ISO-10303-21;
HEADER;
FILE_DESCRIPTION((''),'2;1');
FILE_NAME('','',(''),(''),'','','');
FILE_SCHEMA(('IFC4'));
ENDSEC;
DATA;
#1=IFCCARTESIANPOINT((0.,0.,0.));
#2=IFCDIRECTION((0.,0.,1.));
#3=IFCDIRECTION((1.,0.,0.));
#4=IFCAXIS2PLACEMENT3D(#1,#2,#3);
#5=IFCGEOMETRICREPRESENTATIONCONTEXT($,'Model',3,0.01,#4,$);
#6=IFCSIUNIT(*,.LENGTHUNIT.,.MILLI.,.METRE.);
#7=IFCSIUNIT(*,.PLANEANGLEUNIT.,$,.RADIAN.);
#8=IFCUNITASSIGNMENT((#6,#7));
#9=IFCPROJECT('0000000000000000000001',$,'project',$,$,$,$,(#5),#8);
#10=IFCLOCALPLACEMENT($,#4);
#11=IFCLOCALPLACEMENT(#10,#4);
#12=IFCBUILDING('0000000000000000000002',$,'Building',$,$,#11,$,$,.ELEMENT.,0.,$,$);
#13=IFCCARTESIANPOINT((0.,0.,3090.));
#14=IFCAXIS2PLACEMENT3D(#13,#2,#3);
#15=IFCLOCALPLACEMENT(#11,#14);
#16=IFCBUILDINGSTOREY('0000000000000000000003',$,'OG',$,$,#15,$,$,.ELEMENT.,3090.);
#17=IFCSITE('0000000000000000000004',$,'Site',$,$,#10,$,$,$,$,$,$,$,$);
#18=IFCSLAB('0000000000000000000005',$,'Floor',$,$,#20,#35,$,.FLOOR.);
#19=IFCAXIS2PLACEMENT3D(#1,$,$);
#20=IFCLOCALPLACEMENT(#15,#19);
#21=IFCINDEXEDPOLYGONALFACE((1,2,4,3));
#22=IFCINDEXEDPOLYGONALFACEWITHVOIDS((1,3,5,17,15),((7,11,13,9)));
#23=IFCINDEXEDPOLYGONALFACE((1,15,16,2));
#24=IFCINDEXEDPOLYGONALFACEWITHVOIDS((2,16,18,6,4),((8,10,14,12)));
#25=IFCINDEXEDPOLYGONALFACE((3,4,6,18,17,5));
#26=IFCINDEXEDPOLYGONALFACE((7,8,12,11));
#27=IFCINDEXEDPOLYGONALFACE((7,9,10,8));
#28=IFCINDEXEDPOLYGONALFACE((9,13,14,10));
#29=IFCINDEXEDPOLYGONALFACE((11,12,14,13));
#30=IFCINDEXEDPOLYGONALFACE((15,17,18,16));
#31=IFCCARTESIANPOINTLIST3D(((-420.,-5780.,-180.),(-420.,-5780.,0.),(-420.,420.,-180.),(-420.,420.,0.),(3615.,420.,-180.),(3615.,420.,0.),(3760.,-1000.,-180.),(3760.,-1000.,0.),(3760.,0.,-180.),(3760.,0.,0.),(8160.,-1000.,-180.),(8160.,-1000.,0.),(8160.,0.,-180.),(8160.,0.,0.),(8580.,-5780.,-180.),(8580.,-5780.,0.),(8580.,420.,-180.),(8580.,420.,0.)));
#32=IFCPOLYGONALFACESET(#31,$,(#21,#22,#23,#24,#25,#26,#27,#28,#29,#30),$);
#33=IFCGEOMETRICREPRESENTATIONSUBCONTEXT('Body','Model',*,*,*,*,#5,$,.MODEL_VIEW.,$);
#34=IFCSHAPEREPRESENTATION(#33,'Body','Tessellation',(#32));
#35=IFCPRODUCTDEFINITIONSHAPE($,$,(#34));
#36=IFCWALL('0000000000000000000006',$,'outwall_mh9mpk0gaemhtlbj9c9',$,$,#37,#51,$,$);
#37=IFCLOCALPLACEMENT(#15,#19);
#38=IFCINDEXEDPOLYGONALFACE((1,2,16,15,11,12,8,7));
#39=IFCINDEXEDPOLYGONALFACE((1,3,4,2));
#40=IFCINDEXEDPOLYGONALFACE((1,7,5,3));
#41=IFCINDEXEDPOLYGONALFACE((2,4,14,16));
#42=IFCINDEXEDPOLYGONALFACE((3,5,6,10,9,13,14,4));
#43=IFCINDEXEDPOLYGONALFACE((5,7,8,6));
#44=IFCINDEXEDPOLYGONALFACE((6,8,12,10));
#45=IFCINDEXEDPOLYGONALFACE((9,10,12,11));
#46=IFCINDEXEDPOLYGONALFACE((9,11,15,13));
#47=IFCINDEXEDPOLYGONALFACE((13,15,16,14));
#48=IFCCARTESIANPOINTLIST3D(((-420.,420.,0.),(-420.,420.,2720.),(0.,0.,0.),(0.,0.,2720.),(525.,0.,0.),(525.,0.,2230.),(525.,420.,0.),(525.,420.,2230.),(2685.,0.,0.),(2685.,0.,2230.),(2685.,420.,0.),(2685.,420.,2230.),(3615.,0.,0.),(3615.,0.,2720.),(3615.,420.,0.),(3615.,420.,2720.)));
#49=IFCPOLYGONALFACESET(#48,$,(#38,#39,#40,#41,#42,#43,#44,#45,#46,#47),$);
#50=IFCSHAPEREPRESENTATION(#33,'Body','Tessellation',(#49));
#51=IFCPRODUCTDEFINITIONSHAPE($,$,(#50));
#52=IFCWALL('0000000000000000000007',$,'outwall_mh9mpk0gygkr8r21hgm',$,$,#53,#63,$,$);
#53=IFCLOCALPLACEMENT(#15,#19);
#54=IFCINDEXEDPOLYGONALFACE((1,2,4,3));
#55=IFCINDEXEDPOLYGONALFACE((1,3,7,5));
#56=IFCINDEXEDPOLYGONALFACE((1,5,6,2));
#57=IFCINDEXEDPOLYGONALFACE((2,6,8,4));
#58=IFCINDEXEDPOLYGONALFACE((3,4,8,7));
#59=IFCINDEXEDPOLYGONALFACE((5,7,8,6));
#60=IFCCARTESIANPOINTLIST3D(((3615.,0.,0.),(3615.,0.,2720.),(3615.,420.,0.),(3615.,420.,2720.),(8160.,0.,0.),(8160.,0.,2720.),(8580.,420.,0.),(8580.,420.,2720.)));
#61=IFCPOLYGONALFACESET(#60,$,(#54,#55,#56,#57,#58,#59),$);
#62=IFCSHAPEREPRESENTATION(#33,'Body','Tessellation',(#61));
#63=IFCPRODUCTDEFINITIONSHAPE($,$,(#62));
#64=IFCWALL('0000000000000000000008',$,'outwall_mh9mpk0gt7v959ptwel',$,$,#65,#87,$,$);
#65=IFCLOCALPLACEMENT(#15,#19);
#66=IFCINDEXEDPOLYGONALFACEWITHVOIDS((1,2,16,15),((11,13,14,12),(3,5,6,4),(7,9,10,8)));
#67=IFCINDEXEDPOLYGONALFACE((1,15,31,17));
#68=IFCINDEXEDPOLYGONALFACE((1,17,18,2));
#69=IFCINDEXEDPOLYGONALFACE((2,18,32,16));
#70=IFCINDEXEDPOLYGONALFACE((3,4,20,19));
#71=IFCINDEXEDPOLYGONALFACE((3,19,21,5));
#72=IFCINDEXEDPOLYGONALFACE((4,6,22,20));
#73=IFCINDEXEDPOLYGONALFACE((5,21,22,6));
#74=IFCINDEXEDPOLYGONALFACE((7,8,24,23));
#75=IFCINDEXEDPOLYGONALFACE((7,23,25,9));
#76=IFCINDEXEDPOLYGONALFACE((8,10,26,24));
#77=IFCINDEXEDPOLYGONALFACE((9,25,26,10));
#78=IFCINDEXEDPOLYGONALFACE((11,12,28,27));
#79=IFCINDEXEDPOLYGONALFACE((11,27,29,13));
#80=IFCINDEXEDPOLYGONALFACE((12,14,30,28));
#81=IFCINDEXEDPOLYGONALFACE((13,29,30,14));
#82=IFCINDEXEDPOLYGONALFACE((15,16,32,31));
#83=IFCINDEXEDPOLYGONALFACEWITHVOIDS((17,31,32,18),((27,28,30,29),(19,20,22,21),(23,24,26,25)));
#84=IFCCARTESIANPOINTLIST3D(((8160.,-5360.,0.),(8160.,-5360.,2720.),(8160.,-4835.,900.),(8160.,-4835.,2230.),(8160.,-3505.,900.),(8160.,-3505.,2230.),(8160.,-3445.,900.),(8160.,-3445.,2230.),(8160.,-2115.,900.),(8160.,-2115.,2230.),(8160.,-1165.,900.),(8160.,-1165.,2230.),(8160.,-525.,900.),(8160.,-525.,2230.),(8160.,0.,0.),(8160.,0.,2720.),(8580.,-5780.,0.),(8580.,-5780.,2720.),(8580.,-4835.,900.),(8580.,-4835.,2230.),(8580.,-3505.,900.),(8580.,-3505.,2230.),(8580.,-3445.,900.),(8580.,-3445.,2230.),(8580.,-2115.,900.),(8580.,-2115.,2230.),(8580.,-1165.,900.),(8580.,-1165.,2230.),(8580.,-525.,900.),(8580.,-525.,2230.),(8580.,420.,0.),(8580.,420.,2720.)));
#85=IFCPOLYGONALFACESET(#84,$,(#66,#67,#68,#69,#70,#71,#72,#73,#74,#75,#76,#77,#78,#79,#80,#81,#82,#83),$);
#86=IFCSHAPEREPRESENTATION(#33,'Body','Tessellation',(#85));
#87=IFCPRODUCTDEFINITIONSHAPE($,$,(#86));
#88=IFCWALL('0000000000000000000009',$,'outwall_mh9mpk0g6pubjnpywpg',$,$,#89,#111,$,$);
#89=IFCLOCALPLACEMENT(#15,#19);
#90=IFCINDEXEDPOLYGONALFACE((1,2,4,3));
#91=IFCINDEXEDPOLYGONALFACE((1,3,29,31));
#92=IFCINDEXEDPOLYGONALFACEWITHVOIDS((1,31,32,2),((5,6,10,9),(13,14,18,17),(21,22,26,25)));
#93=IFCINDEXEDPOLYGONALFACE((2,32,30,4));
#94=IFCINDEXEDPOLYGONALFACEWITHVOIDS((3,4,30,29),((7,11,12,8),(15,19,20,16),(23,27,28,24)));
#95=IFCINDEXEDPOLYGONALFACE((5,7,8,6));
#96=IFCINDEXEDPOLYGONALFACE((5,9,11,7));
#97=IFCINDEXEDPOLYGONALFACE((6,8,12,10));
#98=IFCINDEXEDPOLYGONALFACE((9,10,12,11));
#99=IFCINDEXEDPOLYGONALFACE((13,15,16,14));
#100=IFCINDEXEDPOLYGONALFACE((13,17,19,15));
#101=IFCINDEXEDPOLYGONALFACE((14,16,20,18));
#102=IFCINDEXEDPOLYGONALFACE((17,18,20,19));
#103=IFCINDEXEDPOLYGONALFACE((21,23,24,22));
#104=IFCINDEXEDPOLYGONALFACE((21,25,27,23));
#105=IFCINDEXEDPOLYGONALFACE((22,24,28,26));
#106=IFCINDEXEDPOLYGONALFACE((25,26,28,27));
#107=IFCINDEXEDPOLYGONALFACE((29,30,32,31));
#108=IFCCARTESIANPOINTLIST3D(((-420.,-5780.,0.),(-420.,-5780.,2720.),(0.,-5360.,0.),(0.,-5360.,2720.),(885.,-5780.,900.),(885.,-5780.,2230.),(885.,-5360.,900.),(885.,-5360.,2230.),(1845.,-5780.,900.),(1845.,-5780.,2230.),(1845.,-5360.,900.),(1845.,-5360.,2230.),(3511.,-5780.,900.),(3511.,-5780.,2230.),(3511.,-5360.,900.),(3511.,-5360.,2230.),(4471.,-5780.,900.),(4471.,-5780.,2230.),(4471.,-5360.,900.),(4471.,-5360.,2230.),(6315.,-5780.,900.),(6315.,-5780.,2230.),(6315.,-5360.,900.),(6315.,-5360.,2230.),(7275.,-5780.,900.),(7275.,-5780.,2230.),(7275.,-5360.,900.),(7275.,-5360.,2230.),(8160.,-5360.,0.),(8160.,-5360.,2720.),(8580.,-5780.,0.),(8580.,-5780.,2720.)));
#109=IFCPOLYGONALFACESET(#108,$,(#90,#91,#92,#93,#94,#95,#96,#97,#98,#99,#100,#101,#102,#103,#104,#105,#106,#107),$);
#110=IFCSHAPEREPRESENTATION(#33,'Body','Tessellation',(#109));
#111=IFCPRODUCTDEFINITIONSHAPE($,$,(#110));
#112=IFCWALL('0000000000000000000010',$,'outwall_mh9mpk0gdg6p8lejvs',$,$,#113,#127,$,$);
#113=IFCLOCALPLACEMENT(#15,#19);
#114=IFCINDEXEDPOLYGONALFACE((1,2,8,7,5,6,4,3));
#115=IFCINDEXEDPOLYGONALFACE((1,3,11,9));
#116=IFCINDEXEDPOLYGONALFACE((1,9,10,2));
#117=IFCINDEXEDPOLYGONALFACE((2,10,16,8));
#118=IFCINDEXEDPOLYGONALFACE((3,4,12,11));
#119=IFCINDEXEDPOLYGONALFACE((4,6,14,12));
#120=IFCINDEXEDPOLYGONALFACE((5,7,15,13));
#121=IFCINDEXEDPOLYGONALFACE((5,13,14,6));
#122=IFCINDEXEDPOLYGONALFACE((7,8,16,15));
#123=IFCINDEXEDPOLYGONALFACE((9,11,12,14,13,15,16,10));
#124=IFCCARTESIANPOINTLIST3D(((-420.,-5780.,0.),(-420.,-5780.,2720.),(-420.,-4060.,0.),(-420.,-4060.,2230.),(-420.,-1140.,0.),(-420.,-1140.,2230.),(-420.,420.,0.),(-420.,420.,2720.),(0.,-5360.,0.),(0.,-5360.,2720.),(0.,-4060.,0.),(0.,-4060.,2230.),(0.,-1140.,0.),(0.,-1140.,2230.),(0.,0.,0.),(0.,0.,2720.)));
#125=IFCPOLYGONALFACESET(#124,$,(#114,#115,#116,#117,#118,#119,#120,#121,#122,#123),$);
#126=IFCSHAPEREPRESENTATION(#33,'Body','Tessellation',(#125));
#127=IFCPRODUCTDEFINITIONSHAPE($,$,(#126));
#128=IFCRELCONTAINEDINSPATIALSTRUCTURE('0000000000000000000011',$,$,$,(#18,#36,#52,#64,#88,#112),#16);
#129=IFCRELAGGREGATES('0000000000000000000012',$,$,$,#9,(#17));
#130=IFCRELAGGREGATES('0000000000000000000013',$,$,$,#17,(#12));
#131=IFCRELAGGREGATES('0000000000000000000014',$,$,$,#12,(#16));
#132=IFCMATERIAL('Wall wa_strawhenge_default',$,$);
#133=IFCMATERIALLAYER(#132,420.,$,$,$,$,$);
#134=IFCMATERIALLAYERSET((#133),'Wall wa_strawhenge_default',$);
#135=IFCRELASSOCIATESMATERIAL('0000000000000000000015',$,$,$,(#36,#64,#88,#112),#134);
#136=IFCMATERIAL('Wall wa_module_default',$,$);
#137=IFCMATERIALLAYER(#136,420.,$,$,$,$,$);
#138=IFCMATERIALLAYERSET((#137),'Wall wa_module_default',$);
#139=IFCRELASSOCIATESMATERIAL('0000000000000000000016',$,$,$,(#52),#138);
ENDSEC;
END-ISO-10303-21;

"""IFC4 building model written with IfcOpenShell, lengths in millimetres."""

from ifc_helpers import new_model, si_unit, frame, origin_with_axes, place, context, subcontext, project, spatial, polyline, outline, extrude, material, layer, layer_set, layer_usage, element, save


model = new_model("IFC4")

# Units and contexts
model_context = context("Model", 3, precision=0.01, world=origin_with_axes())
body_context = subcontext(model_context, "Body", "Model", "MODEL_VIEW")
ifc_project = project(units=[si_unit("LENGTHUNIT", "METRE", prefix="MILLI"), si_unit("PLANEANGLEUNIT", "RADIAN")], contexts=[model_context])

# Site, building, storey
site_placement = place(None, origin_with_axes())
site = spatial("IfcSite", under=ifc_project, at=site_placement, Name="Site")
building_placement = place(site_placement, origin_with_axes())
building = spatial("IfcBuilding", under=site, at=building_placement, Name="Building", CompositionType="ELEMENT", ElevationOfRefHeight=0.0)
storey_placement = place(building_placement, frame((0.0, 0.0, 3090.0), z_axis=(0.0, 0.0, 1.0), x_axis=(1.0, 0.0, 0.0)))
storey = spatial("IfcBuildingStorey", under=building, at=storey_placement, Name="OG", CompositionType="ELEMENT", Elevation=3090.0)

# Slab
slab_placement = place(storey_placement, origin_with_axes())
element("IfcSlab", 1, at=slab_placement, inside=storey, Name="Floor", PredefinedType="FLOOR", context=body_context, shape_type="SweptSolid", body=[
    extrude(outline(polyline([(8580.0, -5780.0), (8580.0, 420.0), (3615.0, 420.0), (-420.0, 420.0), (-420.0, -5780.0), (8580.0, -5780.0)]), holes=[polyline([(3760.0, -1000.0), (3760.0, 0.0), (8160.0, 0.0), (8160.0, -1000.0), (3760.0, -1000.0)])]), origin_with_axes(), (0.0, 0.0, -1.0), 180.0),
])

# Wall, opening
ifc_material_1 = material(Name="Wall wa_strawhenge_default")
ifc_layer_1 = layer(ifc_material_1, 420.0)
ifc_layer_set_1 = layer_set([ifc_layer_1], Name="Wall wa_strawhenge_default")
ifc_layer_usage_1 = layer_usage(ifc_layer_set_1, "AXIS2", "POSITIVE", 0.0)
wall_1_placement = place(storey_placement, origin_with_axes())
wall_1 = element("IfcWall", 2, at=wall_1_placement, inside=storey, material=ifc_layer_usage_1, Name="outwall_mh9mpk0gaemhtlbj9c9", context=body_context, shape_type="SweptSolid", body=[
    extrude(outline(polyline([(0.0, 0.0), (3615.0, 0.0), (3615.0, 420.0), (-420.0, 420.0), (0.0, 0.0)])), origin_with_axes(), (0.0, 0.0, 1.0), 2720.0),
])
opening_1_placement = place(wall_1_placement, frame((525.0, 0.0, 0.0), z_axis=(0.0, 0.0, 1.0), x_axis=(1.0, 0.0, 0.0)))
element("IfcOpeningElement", 3, at=opening_1_placement, cuts=wall_1, context=body_context, shape_type="SweptSolid", body=[
    extrude(outline(polyline([(0.0, 0.0), (2160.0, 0.0), (2160.0, 420.0), (0.0, 420.0), (0.0, 0.0)])), origin_with_axes(), (0.0, 0.0, 1.0), 2230.0),
])

# Wall
ifc_material_2 = material(Name="Wall wa_module_default")
ifc_layer_2 = layer(ifc_material_2, 420.0)
ifc_layer_set_2 = layer_set([ifc_layer_2], Name="Wall wa_module_default")
ifc_layer_usage_2 = layer_usage(ifc_layer_set_2, "AXIS2", "POSITIVE", 0.0)
wall_2_placement = place(storey_placement, frame((3615.0, 0.0, 0.0), z_axis=(0.0, 0.0, 1.0), x_axis=(1.0, 0.0, 0.0)))
element("IfcWall", 4, at=wall_2_placement, inside=storey, material=ifc_layer_usage_2, Name="outwall_mh9mpk0gygkr8r21hgm", context=body_context, shape_type="SweptSolid", body=[
    extrude(outline(polyline([(0.0, 0.0), (4545.0, 0.0), (4965.0, 420.0), (0.0, 420.0), (0.0, 0.0)])), origin_with_axes(), (0.0, 0.0, 1.0), 2720.0),
])

# Walls, openings
wall_3_placement = place(storey_placement, frame((8160.0, 0.0, 0.0), z_axis=(0.0, 0.0, 1.0), x_axis=(0.0, -1.0, 0.0)))
wall_3 = element("IfcWall", 5, at=wall_3_placement, inside=storey, material=ifc_layer_usage_1, Name="outwall_mh9mpk0gt7v959ptwel", context=body_context, shape_type="SweptSolid", body=[
    extrude(outline(polyline([(0.0, 0.0), (5360.0, 0.0), (5780.0, 420.0), (-420.0, 420.0), (0.0, 0.0)])), origin_with_axes(), (0.0, 0.0, 1.0), 2720.0),
])
opening_2_placement = place(wall_3_placement, frame((3505.0, 0.0, 900.0), z_axis=(0.0, 0.0, 1.0), x_axis=(1.0, 0.0, 0.0)))
element("IfcOpeningElement", 6, at=opening_2_placement, cuts=wall_3, context=body_context, shape_type="SweptSolid", body=[
    extrude(outline(polyline([(0.0, 0.0), (1330.0, 0.0), (1330.0, 420.0), (0.0, 420.0), (0.0, 0.0)])), origin_with_axes(), (0.0, 0.0, 1.0), 1330.0),
])
opening_3_placement = place(wall_3_placement, frame((2115.0, 0.0, 900.0), z_axis=(0.0, 0.0, 1.0), x_axis=(1.0, 0.0, 0.0)))
element("IfcOpeningElement", 7, at=opening_3_placement, cuts=wall_3, context=body_context, shape_type="SweptSolid", body=[
    extrude(outline(polyline([(0.0, 0.0), (1330.0, 0.0), (1330.0, 420.0), (0.0, 420.0), (0.0, 0.0)])), origin_with_axes(), (0.0, 0.0, 1.0), 1330.0),
])
opening_4_placement = place(wall_3_placement, frame((525.0, 0.0, 900.0), z_axis=(0.0, 0.0, 1.0), x_axis=(1.0, 0.0, 0.0)))
element("IfcOpeningElement", 8, at=opening_4_placement, cuts=wall_3, context=body_context, shape_type="SweptSolid", body=[
    extrude(outline(polyline([(0.0, 0.0), (640.0, 0.0), (640.0, 420.0), (0.0, 420.0), (0.0, 0.0)])), origin_with_axes(), (0.0, 0.0, 1.0), 1330.0),
])
wall_4_placement = place(storey_placement, frame((8160.0, -5360.0, 0.0), z_axis=(0.0, 0.0, 1.0), x_axis=(-1.0, 0.0, 0.0)))
wall_4 = element("IfcWall", 9, at=wall_4_placement, inside=storey, material=ifc_layer_usage_1, Name="outwall_mh9mpk0g6pubjnpywpg", context=body_context, shape_type="SweptSolid", body=[
    extrude(outline(polyline([(0.0, 0.0), (8160.0, 0.0), (8580.0, 420.0), (-420.0, 420.0), (0.0, 0.0)])), origin_with_axes(), (0.0, 0.0, 1.0), 2720.0),
])
opening_5_placement = place(wall_4_placement, frame((6315.0, 0.0, 900.0), z_axis=(0.0, 0.0, 1.0), x_axis=(1.0, 0.0, 0.0)))
element("IfcOpeningElement", 10, at=opening_5_placement, cuts=wall_4, context=body_context, shape_type="SweptSolid", body=[
    extrude(outline(polyline([(0.0, 0.0), (960.0, 0.0), (960.0, 420.0), (0.0, 420.0), (0.0, 0.0)])), origin_with_axes(), (0.0, 0.0, 1.0), 1330.0),
])
opening_6_placement = place(wall_4_placement, frame((3689.0, 0.0, 900.0), z_axis=(0.0, 0.0, 1.0), x_axis=(1.0, 0.0, 0.0)))
element("IfcOpeningElement", 11, at=opening_6_placement, cuts=wall_4, context=body_context, shape_type="SweptSolid", body=[
    extrude(outline(polyline([(0.0, 0.0), (960.0, 0.0), (960.0, 420.0), (0.0, 420.0), (0.0, 0.0)])), origin_with_axes(), (0.0, 0.0, 1.0), 1330.0),
])
opening_7_placement = place(wall_4_placement, frame((885.0, 0.0, 900.0), z_axis=(0.0, 0.0, 1.0), x_axis=(1.0, 0.0, 0.0)))
element("IfcOpeningElement", 12, at=opening_7_placement, cuts=wall_4, context=body_context, shape_type="SweptSolid", body=[
    extrude(outline(polyline([(0.0, 0.0), (960.0, 0.0), (960.0, 420.0), (0.0, 420.0), (0.0, 0.0)])), origin_with_axes(), (0.0, 0.0, 1.0), 1330.0),
])

# Wall, opening
wall_5_placement = place(storey_placement, frame((0.0, -5360.0, 0.0), z_axis=(0.0, 0.0, 1.0), x_axis=(0.0, 1.0, 0.0)))
wall_5 = element("IfcWall", 13, at=wall_5_placement, inside=storey, material=ifc_layer_usage_1, Name="outwall_mh9mpk0gdg6p8lejvs", context=body_context, shape_type="SweptSolid", body=[
    extrude(outline(polyline([(0.0, 0.0), (5360.0, 0.0), (5780.0, 420.0), (-420.0, 420.0), (0.0, 0.0)])), origin_with_axes(), (0.0, 0.0, 1.0), 2720.0),
])
opening_8_placement = place(wall_5_placement, frame((1300.0, 0.0, 0.0), z_axis=(0.0, 0.0, 1.0), x_axis=(1.0, 0.0, 0.0)))
element("IfcOpeningElement", 14, at=opening_8_placement, cuts=wall_5, context=body_context, shape_type="SweptSolid", body=[
    extrude(outline(polyline([(0.0, 0.0), (2920.0, 0.0), (2920.0, 420.0), (0.0, 420.0), (0.0, 0.0)])), origin_with_axes(), (0.0, 0.0, 1.0), 2230.0),
])

save(model, "model.ifc")
